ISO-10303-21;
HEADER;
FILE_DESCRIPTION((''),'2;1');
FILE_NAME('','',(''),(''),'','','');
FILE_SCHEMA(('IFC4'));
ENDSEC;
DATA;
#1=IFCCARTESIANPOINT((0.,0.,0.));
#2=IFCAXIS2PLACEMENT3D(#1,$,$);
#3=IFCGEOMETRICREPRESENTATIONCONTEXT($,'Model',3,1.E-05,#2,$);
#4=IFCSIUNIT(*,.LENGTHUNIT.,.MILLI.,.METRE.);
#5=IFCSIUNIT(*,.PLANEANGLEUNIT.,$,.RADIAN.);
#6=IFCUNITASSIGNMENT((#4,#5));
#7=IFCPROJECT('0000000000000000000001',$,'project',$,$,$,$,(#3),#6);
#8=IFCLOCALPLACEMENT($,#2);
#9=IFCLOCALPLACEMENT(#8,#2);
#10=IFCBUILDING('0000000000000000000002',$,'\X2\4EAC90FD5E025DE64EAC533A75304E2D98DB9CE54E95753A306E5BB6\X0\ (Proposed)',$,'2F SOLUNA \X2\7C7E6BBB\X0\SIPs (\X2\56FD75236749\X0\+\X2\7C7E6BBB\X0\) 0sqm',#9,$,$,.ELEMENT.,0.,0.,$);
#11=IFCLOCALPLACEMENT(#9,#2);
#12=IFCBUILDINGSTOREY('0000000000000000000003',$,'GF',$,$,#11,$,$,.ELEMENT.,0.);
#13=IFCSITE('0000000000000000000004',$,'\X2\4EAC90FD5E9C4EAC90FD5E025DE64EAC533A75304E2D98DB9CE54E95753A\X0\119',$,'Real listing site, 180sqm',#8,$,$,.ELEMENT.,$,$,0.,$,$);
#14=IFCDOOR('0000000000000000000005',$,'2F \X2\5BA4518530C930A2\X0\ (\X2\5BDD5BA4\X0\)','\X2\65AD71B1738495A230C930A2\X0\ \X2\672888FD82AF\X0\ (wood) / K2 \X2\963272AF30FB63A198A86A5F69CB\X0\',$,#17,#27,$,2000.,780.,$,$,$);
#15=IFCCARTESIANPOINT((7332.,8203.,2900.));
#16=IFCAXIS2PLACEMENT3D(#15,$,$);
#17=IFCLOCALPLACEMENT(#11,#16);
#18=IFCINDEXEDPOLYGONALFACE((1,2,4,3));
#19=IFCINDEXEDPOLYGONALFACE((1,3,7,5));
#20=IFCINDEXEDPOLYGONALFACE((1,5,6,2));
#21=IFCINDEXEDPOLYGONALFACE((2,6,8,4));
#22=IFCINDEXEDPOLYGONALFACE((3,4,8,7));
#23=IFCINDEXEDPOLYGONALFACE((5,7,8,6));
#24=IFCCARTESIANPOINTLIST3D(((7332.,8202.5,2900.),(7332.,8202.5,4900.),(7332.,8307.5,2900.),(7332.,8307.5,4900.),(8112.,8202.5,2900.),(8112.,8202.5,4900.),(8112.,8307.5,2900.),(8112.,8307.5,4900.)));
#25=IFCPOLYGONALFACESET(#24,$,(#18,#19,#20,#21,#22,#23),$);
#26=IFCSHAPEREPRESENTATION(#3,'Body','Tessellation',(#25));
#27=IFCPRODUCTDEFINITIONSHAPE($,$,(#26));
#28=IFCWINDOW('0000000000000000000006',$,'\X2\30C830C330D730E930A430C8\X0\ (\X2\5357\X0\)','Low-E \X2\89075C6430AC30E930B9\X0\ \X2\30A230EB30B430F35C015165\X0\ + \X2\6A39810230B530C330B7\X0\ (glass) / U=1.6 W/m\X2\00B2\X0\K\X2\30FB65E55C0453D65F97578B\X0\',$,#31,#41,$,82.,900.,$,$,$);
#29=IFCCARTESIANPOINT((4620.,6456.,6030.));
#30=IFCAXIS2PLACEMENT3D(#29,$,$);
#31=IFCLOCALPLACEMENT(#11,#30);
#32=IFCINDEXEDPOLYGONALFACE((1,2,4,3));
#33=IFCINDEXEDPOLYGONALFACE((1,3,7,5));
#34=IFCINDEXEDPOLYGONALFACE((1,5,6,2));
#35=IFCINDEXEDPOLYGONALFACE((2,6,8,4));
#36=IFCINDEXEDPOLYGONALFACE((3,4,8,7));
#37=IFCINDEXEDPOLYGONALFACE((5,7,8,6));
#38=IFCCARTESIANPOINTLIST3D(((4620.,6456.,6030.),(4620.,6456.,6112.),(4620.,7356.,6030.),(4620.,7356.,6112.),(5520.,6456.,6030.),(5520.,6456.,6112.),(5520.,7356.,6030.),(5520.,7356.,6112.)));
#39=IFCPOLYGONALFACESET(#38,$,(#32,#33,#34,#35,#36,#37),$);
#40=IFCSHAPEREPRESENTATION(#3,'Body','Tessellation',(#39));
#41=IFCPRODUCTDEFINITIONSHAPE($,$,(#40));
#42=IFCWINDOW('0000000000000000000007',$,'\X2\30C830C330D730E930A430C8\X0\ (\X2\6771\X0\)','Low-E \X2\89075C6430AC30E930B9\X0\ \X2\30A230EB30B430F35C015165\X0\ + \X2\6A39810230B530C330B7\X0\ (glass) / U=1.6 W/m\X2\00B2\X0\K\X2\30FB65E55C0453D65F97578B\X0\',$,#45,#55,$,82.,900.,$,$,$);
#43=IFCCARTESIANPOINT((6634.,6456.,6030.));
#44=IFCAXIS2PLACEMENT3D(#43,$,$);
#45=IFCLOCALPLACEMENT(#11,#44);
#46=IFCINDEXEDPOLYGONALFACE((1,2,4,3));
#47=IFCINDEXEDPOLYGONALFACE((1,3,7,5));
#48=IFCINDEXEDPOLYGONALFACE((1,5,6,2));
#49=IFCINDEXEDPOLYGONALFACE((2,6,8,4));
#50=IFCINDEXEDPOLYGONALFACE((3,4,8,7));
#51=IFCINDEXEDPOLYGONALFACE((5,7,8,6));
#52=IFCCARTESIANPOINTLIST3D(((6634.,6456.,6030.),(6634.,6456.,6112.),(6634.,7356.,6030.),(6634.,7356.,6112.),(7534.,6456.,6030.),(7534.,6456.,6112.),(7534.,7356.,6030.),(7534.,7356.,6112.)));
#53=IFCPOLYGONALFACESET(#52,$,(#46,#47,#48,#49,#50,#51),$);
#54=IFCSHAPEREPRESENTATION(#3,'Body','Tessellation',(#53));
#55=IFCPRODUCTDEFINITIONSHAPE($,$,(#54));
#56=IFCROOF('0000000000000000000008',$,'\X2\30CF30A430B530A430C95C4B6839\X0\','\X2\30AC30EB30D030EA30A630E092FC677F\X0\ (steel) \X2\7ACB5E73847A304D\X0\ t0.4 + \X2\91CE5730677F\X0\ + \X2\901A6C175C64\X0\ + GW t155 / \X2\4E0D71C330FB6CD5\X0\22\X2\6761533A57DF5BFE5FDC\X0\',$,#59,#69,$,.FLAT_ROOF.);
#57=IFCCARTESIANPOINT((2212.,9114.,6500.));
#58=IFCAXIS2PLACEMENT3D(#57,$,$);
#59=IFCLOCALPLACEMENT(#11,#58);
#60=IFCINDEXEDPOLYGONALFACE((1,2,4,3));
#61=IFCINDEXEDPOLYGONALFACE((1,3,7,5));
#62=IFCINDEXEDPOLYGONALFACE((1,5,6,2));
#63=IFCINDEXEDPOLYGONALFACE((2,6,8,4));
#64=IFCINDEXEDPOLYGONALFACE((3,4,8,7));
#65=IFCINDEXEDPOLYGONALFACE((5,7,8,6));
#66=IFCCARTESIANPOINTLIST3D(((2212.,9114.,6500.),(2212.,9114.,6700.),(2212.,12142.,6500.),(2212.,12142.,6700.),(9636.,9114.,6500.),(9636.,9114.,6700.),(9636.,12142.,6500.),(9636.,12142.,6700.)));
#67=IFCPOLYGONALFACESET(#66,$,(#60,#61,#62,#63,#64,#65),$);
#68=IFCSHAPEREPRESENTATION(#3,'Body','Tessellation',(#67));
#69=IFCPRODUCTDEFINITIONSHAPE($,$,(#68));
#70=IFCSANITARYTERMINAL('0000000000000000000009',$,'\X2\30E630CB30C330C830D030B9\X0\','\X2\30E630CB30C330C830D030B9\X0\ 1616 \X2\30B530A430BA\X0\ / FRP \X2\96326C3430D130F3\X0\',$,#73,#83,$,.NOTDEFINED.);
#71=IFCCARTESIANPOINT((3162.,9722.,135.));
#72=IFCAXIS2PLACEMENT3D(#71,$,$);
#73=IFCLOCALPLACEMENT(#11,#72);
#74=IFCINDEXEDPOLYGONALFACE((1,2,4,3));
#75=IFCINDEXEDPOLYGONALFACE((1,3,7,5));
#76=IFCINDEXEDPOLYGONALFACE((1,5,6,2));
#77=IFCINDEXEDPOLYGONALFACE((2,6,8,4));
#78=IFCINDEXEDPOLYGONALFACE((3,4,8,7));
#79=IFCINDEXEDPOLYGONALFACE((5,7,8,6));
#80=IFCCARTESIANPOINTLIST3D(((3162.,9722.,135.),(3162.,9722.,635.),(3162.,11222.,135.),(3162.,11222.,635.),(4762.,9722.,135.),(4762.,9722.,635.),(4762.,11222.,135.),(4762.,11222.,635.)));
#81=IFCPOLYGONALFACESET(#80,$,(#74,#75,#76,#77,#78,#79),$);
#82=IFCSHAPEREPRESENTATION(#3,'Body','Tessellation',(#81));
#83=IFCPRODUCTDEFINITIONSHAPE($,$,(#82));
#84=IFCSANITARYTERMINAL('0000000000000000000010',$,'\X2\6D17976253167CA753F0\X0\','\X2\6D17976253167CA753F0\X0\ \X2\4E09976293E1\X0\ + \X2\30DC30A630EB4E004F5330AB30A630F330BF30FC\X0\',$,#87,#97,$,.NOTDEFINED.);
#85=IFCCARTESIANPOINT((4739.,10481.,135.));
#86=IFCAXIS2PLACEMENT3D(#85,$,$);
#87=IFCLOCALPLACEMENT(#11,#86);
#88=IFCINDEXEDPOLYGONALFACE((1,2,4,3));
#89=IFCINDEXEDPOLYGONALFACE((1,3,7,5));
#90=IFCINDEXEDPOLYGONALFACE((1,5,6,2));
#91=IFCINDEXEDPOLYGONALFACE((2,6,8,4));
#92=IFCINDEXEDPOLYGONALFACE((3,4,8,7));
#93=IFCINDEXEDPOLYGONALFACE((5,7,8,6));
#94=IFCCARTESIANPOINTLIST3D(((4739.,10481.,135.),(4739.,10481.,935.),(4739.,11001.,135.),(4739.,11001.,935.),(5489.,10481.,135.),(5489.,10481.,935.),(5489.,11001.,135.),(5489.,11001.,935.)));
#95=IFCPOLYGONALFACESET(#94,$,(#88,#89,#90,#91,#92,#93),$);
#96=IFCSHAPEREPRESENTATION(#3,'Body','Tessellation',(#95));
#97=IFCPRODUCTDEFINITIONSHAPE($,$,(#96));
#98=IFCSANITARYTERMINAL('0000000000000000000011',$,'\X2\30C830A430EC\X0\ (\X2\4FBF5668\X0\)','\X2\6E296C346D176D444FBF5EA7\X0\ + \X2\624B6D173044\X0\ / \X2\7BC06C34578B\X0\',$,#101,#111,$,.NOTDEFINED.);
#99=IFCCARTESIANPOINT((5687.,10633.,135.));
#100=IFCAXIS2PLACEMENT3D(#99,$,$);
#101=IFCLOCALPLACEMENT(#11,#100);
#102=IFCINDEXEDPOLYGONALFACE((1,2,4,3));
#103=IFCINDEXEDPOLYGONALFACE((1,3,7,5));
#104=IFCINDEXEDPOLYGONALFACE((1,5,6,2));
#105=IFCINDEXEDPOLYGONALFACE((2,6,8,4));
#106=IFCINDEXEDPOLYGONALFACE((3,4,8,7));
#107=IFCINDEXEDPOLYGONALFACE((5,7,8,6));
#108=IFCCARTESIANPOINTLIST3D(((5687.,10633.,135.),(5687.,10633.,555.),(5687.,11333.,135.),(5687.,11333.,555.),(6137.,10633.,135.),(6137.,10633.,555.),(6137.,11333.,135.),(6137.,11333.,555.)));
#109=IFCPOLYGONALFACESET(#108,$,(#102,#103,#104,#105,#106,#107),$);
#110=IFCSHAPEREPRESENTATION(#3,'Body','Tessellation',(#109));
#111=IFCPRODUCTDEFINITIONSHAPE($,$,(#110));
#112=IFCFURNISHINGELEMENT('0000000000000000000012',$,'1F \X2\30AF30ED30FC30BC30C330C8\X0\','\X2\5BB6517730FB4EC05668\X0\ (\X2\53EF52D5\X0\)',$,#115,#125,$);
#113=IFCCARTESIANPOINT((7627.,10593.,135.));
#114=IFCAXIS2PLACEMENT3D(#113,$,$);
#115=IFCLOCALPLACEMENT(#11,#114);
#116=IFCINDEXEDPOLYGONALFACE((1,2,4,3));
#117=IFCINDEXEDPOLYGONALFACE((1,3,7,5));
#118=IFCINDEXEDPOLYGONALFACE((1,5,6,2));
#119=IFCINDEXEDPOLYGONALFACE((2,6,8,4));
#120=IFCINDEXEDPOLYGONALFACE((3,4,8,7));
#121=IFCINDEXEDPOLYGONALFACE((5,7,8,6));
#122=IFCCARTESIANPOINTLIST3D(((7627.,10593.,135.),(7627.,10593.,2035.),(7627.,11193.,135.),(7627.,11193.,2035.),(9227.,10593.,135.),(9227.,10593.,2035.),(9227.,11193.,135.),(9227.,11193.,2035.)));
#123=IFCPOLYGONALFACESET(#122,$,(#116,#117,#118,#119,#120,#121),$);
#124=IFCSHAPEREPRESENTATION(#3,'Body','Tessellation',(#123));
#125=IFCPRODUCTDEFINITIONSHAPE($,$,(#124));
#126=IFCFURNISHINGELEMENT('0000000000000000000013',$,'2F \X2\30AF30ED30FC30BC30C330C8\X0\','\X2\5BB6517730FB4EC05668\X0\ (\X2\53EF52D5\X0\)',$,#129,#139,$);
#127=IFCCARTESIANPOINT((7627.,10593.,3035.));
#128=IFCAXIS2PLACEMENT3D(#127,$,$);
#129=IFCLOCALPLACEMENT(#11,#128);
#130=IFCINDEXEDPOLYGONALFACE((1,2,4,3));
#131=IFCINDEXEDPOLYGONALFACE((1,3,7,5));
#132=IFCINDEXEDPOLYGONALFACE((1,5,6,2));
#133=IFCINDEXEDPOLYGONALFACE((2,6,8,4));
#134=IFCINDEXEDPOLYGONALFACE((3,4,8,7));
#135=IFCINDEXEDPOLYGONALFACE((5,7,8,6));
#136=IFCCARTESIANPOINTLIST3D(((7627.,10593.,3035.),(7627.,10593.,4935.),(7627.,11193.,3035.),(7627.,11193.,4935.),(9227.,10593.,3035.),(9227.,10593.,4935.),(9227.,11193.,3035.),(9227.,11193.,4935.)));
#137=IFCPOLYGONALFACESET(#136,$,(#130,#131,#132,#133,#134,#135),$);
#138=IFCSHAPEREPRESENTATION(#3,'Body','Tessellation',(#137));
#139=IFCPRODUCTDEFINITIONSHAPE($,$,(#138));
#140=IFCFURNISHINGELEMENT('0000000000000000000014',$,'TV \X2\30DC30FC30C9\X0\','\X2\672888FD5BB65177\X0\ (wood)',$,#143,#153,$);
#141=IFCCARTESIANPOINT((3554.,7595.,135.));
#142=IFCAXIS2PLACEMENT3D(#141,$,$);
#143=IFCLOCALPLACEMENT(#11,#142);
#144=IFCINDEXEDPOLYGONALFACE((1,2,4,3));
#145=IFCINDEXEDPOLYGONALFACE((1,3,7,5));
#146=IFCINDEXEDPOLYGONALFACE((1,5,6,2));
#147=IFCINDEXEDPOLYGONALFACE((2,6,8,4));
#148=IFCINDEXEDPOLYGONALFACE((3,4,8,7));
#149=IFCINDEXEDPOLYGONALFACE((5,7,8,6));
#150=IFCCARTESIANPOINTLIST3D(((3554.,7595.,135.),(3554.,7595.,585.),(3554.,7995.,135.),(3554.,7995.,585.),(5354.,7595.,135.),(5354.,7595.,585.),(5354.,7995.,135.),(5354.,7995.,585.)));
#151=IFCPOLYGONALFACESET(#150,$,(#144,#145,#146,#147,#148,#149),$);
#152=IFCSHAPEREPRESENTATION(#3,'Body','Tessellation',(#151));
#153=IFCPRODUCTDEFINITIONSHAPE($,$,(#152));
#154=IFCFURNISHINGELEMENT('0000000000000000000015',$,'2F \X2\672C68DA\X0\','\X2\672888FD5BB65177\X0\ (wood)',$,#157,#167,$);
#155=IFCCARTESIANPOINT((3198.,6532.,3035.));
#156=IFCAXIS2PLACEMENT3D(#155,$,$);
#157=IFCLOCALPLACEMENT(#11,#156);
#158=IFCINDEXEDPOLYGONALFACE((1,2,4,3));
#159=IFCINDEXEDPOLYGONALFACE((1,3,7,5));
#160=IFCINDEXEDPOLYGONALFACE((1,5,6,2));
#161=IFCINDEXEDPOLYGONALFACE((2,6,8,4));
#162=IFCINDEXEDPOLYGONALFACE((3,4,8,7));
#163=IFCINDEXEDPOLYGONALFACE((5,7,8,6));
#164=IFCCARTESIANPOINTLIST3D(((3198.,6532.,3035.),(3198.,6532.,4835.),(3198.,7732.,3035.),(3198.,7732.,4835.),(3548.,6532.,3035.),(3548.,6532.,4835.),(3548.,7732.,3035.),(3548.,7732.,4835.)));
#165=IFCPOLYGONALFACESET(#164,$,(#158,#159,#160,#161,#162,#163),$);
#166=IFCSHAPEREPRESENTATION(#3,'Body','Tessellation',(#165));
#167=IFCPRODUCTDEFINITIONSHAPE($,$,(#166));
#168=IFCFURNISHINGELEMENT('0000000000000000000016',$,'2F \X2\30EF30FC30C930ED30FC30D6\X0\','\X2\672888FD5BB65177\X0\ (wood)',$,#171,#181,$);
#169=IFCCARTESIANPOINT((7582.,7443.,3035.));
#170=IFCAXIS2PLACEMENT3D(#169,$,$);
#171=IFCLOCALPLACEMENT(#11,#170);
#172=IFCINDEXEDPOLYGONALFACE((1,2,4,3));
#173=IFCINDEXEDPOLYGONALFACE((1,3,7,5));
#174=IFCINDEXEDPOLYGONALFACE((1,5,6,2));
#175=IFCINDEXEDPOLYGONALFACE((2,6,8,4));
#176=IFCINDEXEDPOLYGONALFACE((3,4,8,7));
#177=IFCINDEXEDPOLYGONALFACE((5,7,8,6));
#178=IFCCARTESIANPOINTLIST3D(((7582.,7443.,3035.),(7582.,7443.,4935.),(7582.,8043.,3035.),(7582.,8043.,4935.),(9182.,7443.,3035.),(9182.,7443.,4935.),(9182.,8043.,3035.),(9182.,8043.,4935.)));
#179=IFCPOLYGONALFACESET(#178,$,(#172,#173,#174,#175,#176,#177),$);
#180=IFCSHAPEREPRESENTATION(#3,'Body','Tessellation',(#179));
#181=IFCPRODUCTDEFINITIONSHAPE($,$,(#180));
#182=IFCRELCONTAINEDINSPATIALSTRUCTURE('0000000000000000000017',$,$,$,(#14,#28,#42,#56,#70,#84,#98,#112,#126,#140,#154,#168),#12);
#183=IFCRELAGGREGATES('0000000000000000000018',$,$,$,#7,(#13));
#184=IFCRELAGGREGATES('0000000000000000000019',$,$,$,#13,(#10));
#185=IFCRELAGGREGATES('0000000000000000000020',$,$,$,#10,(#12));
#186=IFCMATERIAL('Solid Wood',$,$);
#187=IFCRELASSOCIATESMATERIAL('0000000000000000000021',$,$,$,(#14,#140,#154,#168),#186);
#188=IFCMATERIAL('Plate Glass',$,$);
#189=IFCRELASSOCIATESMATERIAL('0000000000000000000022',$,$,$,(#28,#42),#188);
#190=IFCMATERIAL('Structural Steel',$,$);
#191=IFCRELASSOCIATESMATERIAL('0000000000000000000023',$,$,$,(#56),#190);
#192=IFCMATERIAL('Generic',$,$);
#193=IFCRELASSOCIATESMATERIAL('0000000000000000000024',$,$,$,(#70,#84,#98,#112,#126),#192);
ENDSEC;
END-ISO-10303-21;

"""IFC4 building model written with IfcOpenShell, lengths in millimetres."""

from ifc_helpers import new_model, si_unit, frame, frame_2d, origin, place, context, project, spatial, rectangle, extrude, material, element, save


model = new_model("IFC4")

# Units and contexts
model_context = context("Model", 3, precision=1e-05, world=origin())
ifc_project = project(units=[si_unit("LENGTHUNIT", "METRE", prefix="MILLI"), si_unit("PLANEANGLEUNIT", "RADIAN")], contexts=[model_context])

# Site, building, storey
site_placement = place(None, origin())
site = spatial("IfcSite", under=ifc_project, at=site_placement, Name="京都府京都市左京区田中飛鳥井町119", ObjectType="Real listing site, 180sqm", CompositionType="ELEMENT", RefElevation=0.0)
building_placement = place(site_placement, origin())
building = spatial("IfcBuilding", under=site, at=building_placement, Name="京都市左京区田中飛鳥井町の家 (Proposed)", ObjectType="2F SOLUNA 籾殻SIPs (国産杉+籾殻) 0sqm", CompositionType="ELEMENT", ElevationOfRefHeight=0.0, ElevationOfTerrain=0.0)
storey_placement = place(building_placement, origin())
storey = spatial("IfcBuildingStorey", under=building, at=storey_placement, Name="GF", CompositionType="ELEMENT", Elevation=0.0)

# Shared definitions
ifc_material_1 = material(Name="Solid Wood")
ifc_material_2 = material(Name="Plate Glass")

# Door
door_1_placement = place(storey_placement, frame((7332.0, 8203.0, 2900.0)))
element("IfcDoor", 1, at=door_1_placement, inside=storey, material=ifc_material_1, Name="2F 室内ドア (寝室)", Description="断熱玄関ドア 木製芯 (wood) / K2 防犯・採風機構", OverallHeight=2000.0, OverallWidth=780.0, context=model_context, shape_type="SweptSolid", body=[
    extrude(rectangle(XDim=780.0, YDim=105.0, at=frame_2d((390.0, 52.0))), frame((7332.0, 8203.0, 2900.0)), (0.0, 0.0, 1.0), 2000.0),
])

# Windows
window_1_placement = place(storey_placement, frame((4620.0, 6456.0, 6030.0)))
element("IfcWindow", 2, at=window_1_placement, inside=storey, material=ifc_material_2, Name="トップライト (南)", Description="Low-E 複層ガラス アルゴン封入 + 樹脂サッシ (glass) / U=1.6 W/m²K・日射取得型", OverallHeight=82.0, OverallWidth=900.0, context=model_context, shape_type="SweptSolid", body=[
    extrude(rectangle(XDim=900.0, YDim=900.0, at=frame_2d((450.0, 450.0))), frame((4620.0, 6456.0, 6030.0)), (0.0, 0.0, 1.0), 82.0),
])
window_2_placement = place(storey_placement, frame((6634.0, 6456.0, 6030.0)))
element("IfcWindow", 3, at=window_2_placement, inside=storey, material=ifc_material_2, Name="トップライト (東)", Description="Low-E 複層ガラス アルゴン封入 + 樹脂サッシ (glass) / U=1.6 W/m²K・日射取得型", OverallHeight=82.0, OverallWidth=900.0, context=model_context, shape_type="SweptSolid", body=[
    extrude(rectangle(XDim=900.0, YDim=900.0, at=frame_2d((450.0, 450.0))), frame((6634.0, 6456.0, 6030.0)), (0.0, 0.0, 1.0), 82.0),
])

# Roof
ifc_material_3 = material(Name="Structural Steel")
roof_placement = place(storey_placement, frame((2212.0, 9114.0, 6500.0)))
element("IfcRoof", 4, at=roof_placement, inside=storey, material=ifc_material_3, Name="ハイサイド屋根", Description="ガルバリウム鋼板 (steel) 立平葺き t0.4 + 野地板 + 通気層 + GW t155 / 不燃・法22条区域対応", PredefinedType="FLAT_ROOF", context=model_context, shape_type="SweptSolid", body=[
    extrude(rectangle(XDim=7424.0, YDim=3028.0, at=frame_2d((3712.0, 1514.0))), frame((2212.0, 9114.0, 6500.0)), (0.0, 0.0, 1.0), 200.0),
])

# Sanitary terminals
ifc_material_4 = material(Name="Generic")
sanitary_terminal_1_placement = place(storey_placement, frame((3162.0, 9722.0, 135.0)))
element("IfcSanitaryTerminal", 5, at=sanitary_terminal_1_placement, inside=storey, material=ifc_material_4, Name="ユニットバス", Description="ユニットバス 1616 サイズ / FRP 防水パン", PredefinedType="NOTDEFINED", context=model_context, shape_type="SweptSolid", body=[
    extrude(rectangle(XDim=1600.0, YDim=1500.0, at=frame_2d((800.0, 750.0))), frame((3162.0, 9722.0, 135.0)), (0.0, 0.0, 1.0), 500.0),
])
sanitary_terminal_2_placement = place(storey_placement, frame((4739.0, 10481.0, 135.0)))
element("IfcSanitaryTerminal", 6, at=sanitary_terminal_2_placement, inside=storey, material=ifc_material_4, Name="洗面化粧台", Description="洗面化粧台 三面鏡 + ボウル一体カウンター", PredefinedType="NOTDEFINED", context=model_context, shape_type="SweptSolid", body=[
    extrude(rectangle(XDim=750.0, YDim=520.0, at=frame_2d((375.0, 260.0))), frame((4739.0, 10481.0, 135.0)), (0.0, 0.0, 1.0), 800.0),
])
sanitary_terminal_3_placement = place(storey_placement, frame((5687.0, 10633.0, 135.0)))
element("IfcSanitaryTerminal", 7, at=sanitary_terminal_3_placement, inside=storey, material=ifc_material_4, Name="トイレ (便器)", Description="温水洗浄便座 + 手洗い / 節水型", PredefinedType="NOTDEFINED", context=model_context, shape_type="SweptSolid", body=[
    extrude(rectangle(XDim=450.0, YDim=700.0, at=frame_2d((225.0, 350.0))), frame((5687.0, 10633.0, 135.0)), (0.0, 0.0, 1.0), 420.0),
])

# Furnishing elements
furnishing_1_placement = place(storey_placement, frame((7627.0, 10593.0, 135.0)))
element("IfcFurnishingElement", 8, at=furnishing_1_placement, inside=storey, material=ifc_material_4, Name="1F クローゼット", Description="家具・什器 (可動)", context=model_context, shape_type="SweptSolid", body=[
    extrude(rectangle(XDim=1600.0, YDim=600.0, at=frame_2d((800.0, 300.0))), frame((7627.0, 10593.0, 135.0)), (0.0, 0.0, 1.0), 1900.0),
])
furnishing_2_placement = place(storey_placement, frame((7627.0, 10593.0, 3035.0)))
element("IfcFurnishingElement", 9, at=furnishing_2_placement, inside=storey, material=ifc_material_4, Name="2F クローゼット", Description="家具・什器 (可動)", context=model_context, shape_type="SweptSolid", body=[
    extrude(rectangle(XDim=1600.0, YDim=600.0, at=frame_2d((800.0, 300.0))), frame((7627.0, 10593.0, 3035.0)), (0.0, 0.0, 1.0), 1900.0),
])
furnishing_3_placement = place(storey_placement, frame((3554.0, 7595.0, 135.0)))
element("IfcFurnishingElement", 10, at=furnishing_3_placement, inside=storey, material=ifc_material_1, Name="TV ボード", Description="木製家具 (wood)", context=model_context, shape_type="SweptSolid", body=[
    extrude(rectangle(XDim=1800.0, YDim=400.0, at=frame_2d((900.0, 200.0))), frame((3554.0, 7595.0, 135.0)), (0.0, 0.0, 1.0), 450.0),
])
furnishing_4_placement = place(storey_placement, frame((3198.0, 6532.0, 3035.0)))
element("IfcFurnishingElement", 11, at=furnishing_4_placement, inside=storey, material=ifc_material_1, Name="2F 本棚", Description="木製家具 (wood)", context=model_context, shape_type="SweptSolid", body=[
    extrude(rectangle(XDim=350.0, YDim=1200.0, at=frame_2d((175.0, 600.0))), frame((3198.0, 6532.0, 3035.0)), (0.0, 0.0, 1.0), 1800.0),
])
furnishing_5_placement = place(storey_placement, frame((7582.0, 7443.0, 3035.0)))
element("IfcFurnishingElement", 12, at=furnishing_5_placement, inside=storey, material=ifc_material_1, Name="2F ワードローブ", Description="木製家具 (wood)", context=model_context, shape_type="SweptSolid", body=[
    extrude(rectangle(XDim=1600.0, YDim=600.0, at=frame_2d((800.0, 300.0))), frame((7582.0, 7443.0, 3035.0)), (0.0, 0.0, 1.0), 1900.0),
])

save(model, "model.ifc")
